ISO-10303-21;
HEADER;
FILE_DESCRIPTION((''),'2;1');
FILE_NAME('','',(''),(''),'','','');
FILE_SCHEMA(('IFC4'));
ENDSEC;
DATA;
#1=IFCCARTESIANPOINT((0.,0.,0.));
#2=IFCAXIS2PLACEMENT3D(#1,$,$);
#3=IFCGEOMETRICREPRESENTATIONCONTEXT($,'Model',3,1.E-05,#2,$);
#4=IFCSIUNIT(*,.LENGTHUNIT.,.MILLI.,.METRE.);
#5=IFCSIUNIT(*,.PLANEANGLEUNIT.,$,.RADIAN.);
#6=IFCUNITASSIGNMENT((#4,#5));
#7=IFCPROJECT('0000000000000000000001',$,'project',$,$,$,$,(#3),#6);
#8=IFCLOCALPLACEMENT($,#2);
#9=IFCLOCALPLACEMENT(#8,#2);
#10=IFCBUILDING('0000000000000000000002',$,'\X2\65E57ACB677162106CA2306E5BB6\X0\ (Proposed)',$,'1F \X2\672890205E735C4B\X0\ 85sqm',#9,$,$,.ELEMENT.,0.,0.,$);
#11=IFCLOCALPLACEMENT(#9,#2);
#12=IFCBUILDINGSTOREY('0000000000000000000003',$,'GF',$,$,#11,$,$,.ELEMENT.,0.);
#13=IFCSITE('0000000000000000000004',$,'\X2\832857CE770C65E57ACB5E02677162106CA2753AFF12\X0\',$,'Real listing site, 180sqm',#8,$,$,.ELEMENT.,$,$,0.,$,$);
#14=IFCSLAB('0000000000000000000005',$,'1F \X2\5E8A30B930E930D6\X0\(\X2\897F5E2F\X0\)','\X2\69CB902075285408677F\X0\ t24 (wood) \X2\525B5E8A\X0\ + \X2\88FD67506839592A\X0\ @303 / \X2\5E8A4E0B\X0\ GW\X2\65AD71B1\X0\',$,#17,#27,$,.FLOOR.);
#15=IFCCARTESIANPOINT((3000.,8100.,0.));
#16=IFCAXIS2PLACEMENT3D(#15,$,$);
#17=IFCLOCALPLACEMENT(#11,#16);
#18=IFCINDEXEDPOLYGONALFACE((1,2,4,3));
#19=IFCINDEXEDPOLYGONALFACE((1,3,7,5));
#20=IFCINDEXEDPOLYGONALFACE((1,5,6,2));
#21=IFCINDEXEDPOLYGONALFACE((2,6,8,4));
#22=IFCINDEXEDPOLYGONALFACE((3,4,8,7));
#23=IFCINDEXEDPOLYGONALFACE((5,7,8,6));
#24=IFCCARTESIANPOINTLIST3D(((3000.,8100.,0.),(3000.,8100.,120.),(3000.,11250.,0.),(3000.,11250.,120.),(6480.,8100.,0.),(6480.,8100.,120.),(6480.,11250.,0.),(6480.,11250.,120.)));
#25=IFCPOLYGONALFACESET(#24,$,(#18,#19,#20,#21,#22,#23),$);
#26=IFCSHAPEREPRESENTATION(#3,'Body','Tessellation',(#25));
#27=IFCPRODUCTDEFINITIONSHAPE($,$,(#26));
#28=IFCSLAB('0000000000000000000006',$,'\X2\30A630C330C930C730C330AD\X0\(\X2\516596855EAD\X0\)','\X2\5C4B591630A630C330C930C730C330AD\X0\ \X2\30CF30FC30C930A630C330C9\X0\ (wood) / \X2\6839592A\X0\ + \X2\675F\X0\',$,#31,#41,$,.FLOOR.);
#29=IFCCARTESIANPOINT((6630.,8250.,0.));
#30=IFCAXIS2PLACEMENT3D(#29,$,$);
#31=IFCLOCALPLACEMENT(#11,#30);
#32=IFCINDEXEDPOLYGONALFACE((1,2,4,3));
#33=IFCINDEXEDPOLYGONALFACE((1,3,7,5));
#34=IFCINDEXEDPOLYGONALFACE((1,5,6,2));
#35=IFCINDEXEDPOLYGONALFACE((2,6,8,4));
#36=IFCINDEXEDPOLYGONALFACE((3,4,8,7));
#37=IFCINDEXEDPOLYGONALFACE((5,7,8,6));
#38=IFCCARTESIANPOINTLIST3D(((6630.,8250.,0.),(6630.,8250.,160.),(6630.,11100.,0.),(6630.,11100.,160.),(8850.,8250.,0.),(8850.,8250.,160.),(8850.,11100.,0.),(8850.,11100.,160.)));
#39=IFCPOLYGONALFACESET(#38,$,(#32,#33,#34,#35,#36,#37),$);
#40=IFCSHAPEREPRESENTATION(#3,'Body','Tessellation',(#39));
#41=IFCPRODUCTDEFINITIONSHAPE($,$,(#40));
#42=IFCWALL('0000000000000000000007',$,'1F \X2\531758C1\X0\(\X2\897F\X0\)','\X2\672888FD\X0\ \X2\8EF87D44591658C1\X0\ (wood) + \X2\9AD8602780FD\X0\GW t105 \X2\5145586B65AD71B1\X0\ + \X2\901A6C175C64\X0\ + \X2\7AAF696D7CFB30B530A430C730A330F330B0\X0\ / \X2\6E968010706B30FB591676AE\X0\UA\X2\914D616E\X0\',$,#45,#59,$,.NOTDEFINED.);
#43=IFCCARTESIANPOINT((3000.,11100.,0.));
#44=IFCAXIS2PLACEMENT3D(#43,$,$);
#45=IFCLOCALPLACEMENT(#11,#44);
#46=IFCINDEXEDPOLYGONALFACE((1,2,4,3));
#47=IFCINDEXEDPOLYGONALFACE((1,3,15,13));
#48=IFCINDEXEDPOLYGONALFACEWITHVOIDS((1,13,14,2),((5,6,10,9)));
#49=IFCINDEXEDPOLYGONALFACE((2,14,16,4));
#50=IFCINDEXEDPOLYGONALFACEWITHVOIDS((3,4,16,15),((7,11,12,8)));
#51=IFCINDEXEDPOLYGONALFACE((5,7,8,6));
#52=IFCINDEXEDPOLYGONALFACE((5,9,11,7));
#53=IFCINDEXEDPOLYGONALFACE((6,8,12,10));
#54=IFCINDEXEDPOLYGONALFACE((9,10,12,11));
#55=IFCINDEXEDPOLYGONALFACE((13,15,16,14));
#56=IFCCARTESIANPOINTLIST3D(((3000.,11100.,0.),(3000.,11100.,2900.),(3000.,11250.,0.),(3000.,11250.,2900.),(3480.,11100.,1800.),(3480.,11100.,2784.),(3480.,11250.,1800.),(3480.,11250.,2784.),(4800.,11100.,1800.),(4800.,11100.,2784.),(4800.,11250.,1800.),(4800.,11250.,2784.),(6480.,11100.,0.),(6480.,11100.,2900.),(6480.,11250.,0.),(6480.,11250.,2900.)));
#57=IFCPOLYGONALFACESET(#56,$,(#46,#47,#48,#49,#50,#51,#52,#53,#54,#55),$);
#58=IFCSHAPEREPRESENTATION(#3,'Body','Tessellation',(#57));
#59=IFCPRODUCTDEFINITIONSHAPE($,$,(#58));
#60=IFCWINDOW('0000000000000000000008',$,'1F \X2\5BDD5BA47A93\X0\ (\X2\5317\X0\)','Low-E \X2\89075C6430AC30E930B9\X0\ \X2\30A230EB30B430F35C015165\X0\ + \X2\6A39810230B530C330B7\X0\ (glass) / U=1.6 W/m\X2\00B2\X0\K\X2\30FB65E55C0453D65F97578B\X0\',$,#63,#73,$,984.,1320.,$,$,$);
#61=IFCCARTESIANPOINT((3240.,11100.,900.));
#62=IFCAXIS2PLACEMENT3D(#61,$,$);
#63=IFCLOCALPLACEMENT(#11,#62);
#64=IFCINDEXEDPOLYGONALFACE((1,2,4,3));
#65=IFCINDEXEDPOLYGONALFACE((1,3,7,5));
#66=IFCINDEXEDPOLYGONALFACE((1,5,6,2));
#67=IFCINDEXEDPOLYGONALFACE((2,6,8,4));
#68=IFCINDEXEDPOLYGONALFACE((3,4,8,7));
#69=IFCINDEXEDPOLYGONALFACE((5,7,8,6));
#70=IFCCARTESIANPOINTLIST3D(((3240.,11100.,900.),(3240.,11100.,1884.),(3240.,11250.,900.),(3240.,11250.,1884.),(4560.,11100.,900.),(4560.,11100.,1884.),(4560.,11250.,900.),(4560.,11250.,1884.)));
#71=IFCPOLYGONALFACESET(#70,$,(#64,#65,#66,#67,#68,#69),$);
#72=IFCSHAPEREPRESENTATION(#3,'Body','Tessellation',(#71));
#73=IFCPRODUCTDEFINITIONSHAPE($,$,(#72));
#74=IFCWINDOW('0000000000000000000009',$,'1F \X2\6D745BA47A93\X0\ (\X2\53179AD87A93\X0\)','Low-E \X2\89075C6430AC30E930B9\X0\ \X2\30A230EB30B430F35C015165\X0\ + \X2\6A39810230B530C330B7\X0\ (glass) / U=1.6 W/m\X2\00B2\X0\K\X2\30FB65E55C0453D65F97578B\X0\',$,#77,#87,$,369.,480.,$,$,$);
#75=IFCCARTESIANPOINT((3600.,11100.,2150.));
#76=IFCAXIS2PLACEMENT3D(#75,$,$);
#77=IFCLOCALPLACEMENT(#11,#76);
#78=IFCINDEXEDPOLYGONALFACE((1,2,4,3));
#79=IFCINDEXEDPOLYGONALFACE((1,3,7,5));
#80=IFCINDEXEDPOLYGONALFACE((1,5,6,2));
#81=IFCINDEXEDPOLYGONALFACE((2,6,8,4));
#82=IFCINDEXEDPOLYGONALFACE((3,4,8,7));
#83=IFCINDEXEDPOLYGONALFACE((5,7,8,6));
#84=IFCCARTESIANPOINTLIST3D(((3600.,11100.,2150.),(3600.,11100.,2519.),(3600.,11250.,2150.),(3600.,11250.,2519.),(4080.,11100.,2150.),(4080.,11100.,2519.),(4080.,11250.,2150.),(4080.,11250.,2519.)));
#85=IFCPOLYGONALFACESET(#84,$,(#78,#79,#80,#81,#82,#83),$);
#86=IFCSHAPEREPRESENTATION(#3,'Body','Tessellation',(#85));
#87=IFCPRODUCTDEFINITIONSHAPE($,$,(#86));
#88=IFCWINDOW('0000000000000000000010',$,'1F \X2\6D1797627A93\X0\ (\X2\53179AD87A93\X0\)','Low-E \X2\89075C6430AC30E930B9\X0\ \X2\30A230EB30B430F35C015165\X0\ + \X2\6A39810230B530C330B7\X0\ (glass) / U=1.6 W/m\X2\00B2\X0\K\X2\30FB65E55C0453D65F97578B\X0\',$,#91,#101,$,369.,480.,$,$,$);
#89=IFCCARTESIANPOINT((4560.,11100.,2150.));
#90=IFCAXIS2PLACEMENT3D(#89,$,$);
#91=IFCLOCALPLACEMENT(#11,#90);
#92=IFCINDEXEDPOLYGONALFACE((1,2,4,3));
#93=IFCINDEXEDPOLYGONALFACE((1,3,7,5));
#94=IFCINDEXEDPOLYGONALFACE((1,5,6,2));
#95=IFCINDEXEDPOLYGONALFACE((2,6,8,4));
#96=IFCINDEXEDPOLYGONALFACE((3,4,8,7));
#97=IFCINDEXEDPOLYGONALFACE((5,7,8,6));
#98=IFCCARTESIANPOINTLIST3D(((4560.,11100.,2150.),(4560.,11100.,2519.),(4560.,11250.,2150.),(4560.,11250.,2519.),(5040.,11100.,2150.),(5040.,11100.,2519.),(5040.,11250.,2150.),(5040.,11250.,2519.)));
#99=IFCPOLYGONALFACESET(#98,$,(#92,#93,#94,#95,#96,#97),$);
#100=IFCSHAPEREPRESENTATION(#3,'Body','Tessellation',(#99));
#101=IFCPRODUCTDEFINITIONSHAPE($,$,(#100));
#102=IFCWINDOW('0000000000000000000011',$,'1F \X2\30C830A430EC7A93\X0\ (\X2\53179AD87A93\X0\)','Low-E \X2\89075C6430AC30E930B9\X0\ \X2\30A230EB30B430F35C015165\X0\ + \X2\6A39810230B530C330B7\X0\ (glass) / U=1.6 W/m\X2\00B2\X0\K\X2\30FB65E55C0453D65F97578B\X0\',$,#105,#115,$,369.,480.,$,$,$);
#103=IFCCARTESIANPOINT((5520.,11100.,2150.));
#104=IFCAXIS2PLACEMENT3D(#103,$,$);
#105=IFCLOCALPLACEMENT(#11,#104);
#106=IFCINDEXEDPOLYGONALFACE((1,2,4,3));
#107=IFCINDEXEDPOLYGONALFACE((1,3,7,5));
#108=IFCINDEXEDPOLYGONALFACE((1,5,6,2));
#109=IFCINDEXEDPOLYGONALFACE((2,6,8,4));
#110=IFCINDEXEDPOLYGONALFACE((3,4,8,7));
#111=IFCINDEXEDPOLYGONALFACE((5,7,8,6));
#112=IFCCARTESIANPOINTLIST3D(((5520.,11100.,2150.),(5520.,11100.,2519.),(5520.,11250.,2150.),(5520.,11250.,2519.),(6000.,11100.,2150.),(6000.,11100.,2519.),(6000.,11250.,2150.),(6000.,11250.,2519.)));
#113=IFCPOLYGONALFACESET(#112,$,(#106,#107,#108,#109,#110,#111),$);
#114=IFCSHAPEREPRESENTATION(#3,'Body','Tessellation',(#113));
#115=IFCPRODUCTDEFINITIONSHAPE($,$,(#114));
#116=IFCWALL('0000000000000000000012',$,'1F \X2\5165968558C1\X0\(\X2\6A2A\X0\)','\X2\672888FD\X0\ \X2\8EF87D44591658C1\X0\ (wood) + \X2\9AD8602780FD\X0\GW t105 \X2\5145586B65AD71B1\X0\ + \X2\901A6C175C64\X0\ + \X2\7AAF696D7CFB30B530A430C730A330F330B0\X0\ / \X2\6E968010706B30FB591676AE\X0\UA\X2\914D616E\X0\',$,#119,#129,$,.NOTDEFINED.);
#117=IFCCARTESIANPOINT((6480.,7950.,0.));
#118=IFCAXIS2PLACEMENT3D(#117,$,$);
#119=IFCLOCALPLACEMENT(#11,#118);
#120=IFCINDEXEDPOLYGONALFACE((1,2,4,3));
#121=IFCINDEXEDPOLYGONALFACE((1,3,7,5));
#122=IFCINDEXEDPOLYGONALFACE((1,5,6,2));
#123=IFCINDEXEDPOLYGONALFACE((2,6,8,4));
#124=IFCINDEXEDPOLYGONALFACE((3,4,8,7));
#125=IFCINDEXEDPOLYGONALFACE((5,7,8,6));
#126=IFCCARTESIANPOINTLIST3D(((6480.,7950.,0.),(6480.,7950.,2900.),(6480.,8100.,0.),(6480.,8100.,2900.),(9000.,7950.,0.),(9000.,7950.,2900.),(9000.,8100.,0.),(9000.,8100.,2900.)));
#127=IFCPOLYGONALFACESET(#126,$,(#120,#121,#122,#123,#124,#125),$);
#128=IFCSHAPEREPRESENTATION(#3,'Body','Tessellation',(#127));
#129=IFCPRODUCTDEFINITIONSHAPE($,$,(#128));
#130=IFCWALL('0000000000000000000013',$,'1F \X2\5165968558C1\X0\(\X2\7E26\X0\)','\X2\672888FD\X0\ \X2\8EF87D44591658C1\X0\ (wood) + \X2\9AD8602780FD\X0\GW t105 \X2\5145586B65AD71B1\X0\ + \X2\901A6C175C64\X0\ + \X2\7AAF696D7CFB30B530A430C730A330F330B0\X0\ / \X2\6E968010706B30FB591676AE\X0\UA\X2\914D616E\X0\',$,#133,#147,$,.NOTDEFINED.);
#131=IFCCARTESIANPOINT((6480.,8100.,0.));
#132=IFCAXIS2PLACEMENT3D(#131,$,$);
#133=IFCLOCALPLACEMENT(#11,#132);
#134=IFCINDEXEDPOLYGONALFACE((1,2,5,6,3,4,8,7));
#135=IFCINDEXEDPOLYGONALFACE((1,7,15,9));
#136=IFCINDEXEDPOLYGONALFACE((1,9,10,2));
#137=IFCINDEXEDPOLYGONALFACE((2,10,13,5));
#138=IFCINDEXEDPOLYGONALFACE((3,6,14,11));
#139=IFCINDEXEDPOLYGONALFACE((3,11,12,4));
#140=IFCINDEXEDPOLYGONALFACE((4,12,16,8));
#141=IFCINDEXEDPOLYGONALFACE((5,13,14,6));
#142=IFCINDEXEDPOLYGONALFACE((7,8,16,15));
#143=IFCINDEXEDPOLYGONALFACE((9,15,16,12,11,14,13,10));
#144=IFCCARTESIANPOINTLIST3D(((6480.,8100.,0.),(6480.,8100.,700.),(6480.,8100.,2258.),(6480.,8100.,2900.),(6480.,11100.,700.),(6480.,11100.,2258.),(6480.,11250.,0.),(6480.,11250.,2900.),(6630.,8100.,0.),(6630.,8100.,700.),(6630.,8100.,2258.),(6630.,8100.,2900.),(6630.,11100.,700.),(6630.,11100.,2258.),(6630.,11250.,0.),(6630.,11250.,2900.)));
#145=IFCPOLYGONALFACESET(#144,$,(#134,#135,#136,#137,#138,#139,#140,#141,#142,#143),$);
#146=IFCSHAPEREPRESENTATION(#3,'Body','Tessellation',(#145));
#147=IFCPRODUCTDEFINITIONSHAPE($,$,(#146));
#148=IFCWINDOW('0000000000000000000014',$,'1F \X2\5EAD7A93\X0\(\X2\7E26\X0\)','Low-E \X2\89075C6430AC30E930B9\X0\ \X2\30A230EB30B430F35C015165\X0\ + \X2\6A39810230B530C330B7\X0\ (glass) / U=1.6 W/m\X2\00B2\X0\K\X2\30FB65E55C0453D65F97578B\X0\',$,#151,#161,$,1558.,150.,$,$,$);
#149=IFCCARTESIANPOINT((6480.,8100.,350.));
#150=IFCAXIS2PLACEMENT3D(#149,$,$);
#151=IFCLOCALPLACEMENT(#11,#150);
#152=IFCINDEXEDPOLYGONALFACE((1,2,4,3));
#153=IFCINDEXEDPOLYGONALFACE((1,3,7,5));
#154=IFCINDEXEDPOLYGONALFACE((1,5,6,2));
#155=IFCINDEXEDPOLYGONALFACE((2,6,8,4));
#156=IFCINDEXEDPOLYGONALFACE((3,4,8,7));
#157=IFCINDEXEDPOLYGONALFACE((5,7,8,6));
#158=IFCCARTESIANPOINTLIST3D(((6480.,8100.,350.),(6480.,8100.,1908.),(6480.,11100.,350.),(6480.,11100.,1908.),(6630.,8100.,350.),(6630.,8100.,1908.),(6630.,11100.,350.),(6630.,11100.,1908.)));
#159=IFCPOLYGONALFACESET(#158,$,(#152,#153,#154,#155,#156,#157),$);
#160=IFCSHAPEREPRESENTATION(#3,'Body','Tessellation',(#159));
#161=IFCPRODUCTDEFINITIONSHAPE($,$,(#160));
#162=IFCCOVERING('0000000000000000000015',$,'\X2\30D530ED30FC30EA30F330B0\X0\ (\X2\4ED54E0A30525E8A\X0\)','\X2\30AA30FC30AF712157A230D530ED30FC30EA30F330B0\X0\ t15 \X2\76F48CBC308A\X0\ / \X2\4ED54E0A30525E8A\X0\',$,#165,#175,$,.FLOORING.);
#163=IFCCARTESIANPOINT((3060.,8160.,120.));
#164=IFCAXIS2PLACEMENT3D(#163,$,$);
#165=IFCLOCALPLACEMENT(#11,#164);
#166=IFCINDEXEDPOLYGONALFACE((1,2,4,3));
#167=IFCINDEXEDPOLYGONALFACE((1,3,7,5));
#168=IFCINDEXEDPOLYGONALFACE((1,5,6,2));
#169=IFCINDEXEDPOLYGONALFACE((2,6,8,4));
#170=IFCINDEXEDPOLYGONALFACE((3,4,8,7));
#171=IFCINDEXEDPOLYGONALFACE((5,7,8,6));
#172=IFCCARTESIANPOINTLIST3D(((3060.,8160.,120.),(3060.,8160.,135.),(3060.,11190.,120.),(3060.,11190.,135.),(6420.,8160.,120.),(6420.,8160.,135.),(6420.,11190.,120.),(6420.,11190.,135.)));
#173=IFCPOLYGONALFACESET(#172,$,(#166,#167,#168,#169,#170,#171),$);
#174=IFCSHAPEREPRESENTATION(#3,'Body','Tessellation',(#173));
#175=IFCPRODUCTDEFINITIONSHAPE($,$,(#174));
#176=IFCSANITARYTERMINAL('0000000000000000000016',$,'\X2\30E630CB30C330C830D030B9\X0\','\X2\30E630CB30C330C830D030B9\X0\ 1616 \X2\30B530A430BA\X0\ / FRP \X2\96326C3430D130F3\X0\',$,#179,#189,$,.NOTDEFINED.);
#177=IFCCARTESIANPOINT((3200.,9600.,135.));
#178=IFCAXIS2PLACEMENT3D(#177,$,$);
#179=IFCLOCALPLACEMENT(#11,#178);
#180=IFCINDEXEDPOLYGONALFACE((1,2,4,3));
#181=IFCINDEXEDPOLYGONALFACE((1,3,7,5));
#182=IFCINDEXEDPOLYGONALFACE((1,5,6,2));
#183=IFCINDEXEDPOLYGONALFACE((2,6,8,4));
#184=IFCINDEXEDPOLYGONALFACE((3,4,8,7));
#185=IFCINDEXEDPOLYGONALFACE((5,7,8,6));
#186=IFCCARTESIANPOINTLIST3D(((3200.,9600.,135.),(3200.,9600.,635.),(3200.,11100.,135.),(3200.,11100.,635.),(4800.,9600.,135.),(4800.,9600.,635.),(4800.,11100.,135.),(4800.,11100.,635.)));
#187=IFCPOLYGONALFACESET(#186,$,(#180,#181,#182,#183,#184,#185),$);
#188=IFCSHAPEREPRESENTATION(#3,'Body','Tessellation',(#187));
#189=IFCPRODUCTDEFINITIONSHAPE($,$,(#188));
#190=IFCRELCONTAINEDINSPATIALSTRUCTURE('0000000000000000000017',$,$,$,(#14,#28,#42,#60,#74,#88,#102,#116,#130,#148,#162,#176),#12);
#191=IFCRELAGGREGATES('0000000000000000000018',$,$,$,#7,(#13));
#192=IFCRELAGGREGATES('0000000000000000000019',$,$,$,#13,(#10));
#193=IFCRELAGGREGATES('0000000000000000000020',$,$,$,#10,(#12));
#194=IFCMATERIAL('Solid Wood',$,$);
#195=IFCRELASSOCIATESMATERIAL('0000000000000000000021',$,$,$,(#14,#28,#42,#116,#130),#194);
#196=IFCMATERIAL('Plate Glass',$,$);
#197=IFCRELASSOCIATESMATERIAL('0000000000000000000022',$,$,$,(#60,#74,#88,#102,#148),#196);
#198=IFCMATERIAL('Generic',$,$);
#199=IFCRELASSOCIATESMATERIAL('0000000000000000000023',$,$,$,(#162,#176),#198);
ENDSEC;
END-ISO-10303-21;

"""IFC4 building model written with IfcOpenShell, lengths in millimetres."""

from ifc_helpers import new_model, si_unit, frame, frame_2d, origin, place, context, project, spatial, rectangle, extrude, material, element, fill, save


model = new_model("IFC4")

# Units and contexts
model_context = context("Model", 3, precision=1e-05, world=origin())
ifc_project = project(units=[si_unit("LENGTHUNIT", "METRE", prefix="MILLI"), si_unit("PLANEANGLEUNIT", "RADIAN")], contexts=[model_context])

# Site, building, storey
site_placement = place(None, origin())
site = spatial("IfcSite", under=ifc_project, at=site_placement, Name="茨城県日立市東成沢町２", ObjectType="Real listing site, 180sqm", CompositionType="ELEMENT", RefElevation=0.0)
building_placement = place(site_placement, origin())
building = spatial("IfcBuilding", under=site, at=building_placement, Name="日立東成沢の家 (Proposed)", ObjectType="1F 木造平屋 85sqm", CompositionType="ELEMENT", ElevationOfRefHeight=0.0, ElevationOfTerrain=0.0)
storey_placement = place(building_placement, origin())
storey = spatial("IfcBuildingStorey", under=building, at=storey_placement, Name="GF", CompositionType="ELEMENT", Elevation=0.0)

# Slabs
ifc_material_1 = material(Name="Solid Wood")
slab_1_placement = place(storey_placement, frame((3000.0, 8100.0, 0.0)))
element("IfcSlab", 1, at=slab_1_placement, inside=storey, material=ifc_material_1, Name="1F 床スラブ(西帯)", Description="構造用合板 t24 (wood) 剛床 + 製材根太 @303 / 床下 GW断熱", PredefinedType="FLOOR", context=model_context, shape_type="SweptSolid", body=[
    extrude(rectangle(XDim=3480.0, YDim=3150.0, at=frame_2d((1740.0, 1575.0))), frame((3000.0, 8100.0, 0.0)), (0.0, 0.0, 1.0), 120.0),
])
slab_2_placement = place(storey_placement, frame((6630.0, 8250.0, 0.0)))
element("IfcSlab", 2, at=slab_2_placement, inside=storey, material=ifc_material_1, Name="ウッドデッキ(入隅庭)", Description="屋外ウッドデッキ ハードウッド (wood) / 根太 + 束", PredefinedType="FLOOR", context=model_context, shape_type="SweptSolid", body=[
    extrude(rectangle(XDim=2220.0, YDim=2850.0, at=frame_2d((1110.0, 1425.0))), frame((6630.0, 8250.0, 0.0)), (0.0, 0.0, 1.0), 160.0),
])

# Wall, openings, windows
wall_1_placement = place(storey_placement, frame((3000.0, 11100.0, 0.0)))
wall_1 = element("IfcWall", 3, at=wall_1_placement, inside=storey, material=ifc_material_1, Name="1F 北壁(西)", Description="木製 軸組外壁 (wood) + 高性能GW t105 充填断熱 + 通気層 + 窯業系サイディング / 準耐火・外皮UA配慮", PredefinedType="NOTDEFINED", context=model_context, shape_type="SweptSolid", body=[
    extrude(rectangle(XDim=3480.0, YDim=150.0, at=frame_2d((1740.0, 75.0))), frame((3000.0, 11100.0, 0.0)), (0.0, 0.0, 1.0), 2900.0),
])
opening_1_placement = place(storey_placement, frame((3240.0, 11100.0, 900.0)))
opening_1 = element("IfcOpeningElement", 4, at=opening_1_placement, cuts=wall_1, PredefinedType="NOTDEFINED", context=model_context, shape_type="SweptSolid", body=[
    extrude(rectangle(XDim=1320.0, YDim=150.0, at=frame_2d((660.0, 75.0))), frame((3240.0, 11100.0, 900.0)), (0.0, 0.0, 1.0), 984.0),
])
opening_2_placement = place(storey_placement, frame((3600.0, 11100.0, 2150.0)))
opening_2 = element("IfcOpeningElement", 5, at=opening_2_placement, cuts=wall_1, PredefinedType="NOTDEFINED", context=model_context, shape_type="SweptSolid", body=[
    extrude(rectangle(XDim=480.0, YDim=150.0, at=frame_2d((240.0, 75.0))), frame((3600.0, 11100.0, 2150.0)), (0.0, 0.0, 1.0), 369.0),
])
opening_3_placement = place(storey_placement, frame((4560.0, 11100.0, 2150.0)))
opening_3 = element("IfcOpeningElement", 6, at=opening_3_placement, cuts=wall_1, PredefinedType="NOTDEFINED", context=model_context, shape_type="SweptSolid", body=[
    extrude(rectangle(XDim=480.0, YDim=150.0, at=frame_2d((240.0, 75.0))), frame((4560.0, 11100.0, 2150.0)), (0.0, 0.0, 1.0), 369.0),
])
opening_4_placement = place(storey_placement, frame((5520.0, 11100.0, 2150.0)))
opening_4 = element("IfcOpeningElement", 7, at=opening_4_placement, cuts=wall_1, PredefinedType="NOTDEFINED", context=model_context, shape_type="SweptSolid", body=[
    extrude(rectangle(XDim=480.0, YDim=150.0, at=frame_2d((240.0, 75.0))), frame((5520.0, 11100.0, 2150.0)), (0.0, 0.0, 1.0), 369.0),
])
ifc_material_2 = material(Name="Plate Glass")
window_1_placement = place(storey_placement, frame((3240.0, 11100.0, 900.0)))
window_1 = element("IfcWindow", 8, at=window_1_placement, inside=storey, material=ifc_material_2, Name="1F 寝室窓 (北)", Description="Low-E 複層ガラス アルゴン封入 + 樹脂サッシ (glass) / U=1.6 W/m²K・日射取得型", OverallHeight=984.0, OverallWidth=1320.0, context=model_context, shape_type="SweptSolid", body=[
    extrude(rectangle(XDim=1320.0, YDim=150.0, at=frame_2d((660.0, 75.0))), frame((3240.0, 11100.0, 900.0)), (0.0, 0.0, 1.0), 984.0),
])
fill(opening_1, window_1)
window_2_placement = place(storey_placement, frame((3600.0, 11100.0, 2150.0)))
window_2 = element("IfcWindow", 9, at=window_2_placement, inside=storey, material=ifc_material_2, Name="1F 浴室窓 (北高窓)", Description="Low-E 複層ガラス アルゴン封入 + 樹脂サッシ (glass) / U=1.6 W/m²K・日射取得型", OverallHeight=369.0, OverallWidth=480.0, context=model_context, shape_type="SweptSolid", body=[
    extrude(rectangle(XDim=480.0, YDim=150.0, at=frame_2d((240.0, 75.0))), frame((3600.0, 11100.0, 2150.0)), (0.0, 0.0, 1.0), 369.0),
])
fill(opening_2, window_2)
window_3_placement = place(storey_placement, frame((4560.0, 11100.0, 2150.0)))
window_3 = element("IfcWindow", 10, at=window_3_placement, inside=storey, material=ifc_material_2, Name="1F 洗面窓 (北高窓)", Description="Low-E 複層ガラス アルゴン封入 + 樹脂サッシ (glass) / U=1.6 W/m²K・日射取得型", OverallHeight=369.0, OverallWidth=480.0, context=model_context, shape_type="SweptSolid", body=[
    extrude(rectangle(XDim=480.0, YDim=150.0, at=frame_2d((240.0, 75.0))), frame((4560.0, 11100.0, 2150.0)), (0.0, 0.0, 1.0), 369.0),
])
fill(opening_3, window_3)
window_4_placement = place(storey_placement, frame((5520.0, 11100.0, 2150.0)))
window_4 = element("IfcWindow", 11, at=window_4_placement, inside=storey, material=ifc_material_2, Name="1F トイレ窓 (北高窓)", Description="Low-E 複層ガラス アルゴン封入 + 樹脂サッシ (glass) / U=1.6 W/m²K・日射取得型", OverallHeight=369.0, OverallWidth=480.0, context=model_context, shape_type="SweptSolid", body=[
    extrude(rectangle(XDim=480.0, YDim=150.0, at=frame_2d((240.0, 75.0))), frame((5520.0, 11100.0, 2150.0)), (0.0, 0.0, 1.0), 369.0),
])
fill(opening_4, window_4)

# Wall
wall_2_placement = place(storey_placement, frame((6480.0, 7950.0, 0.0)))
element("IfcWall", 12, at=wall_2_placement, inside=storey, material=ifc_material_1, Name="1F 入隅壁(横)", Description="木製 軸組外壁 (wood) + 高性能GW t105 充填断熱 + 通気層 + 窯業系サイディング / 準耐火・外皮UA配慮", PredefinedType="NOTDEFINED", context=model_context, shape_type="SweptSolid", body=[
    extrude(rectangle(XDim=2520.0, YDim=150.0, at=frame_2d((1260.0, 75.0))), frame((6480.0, 7950.0, 0.0)), (0.0, 0.0, 1.0), 2900.0),
])

# Wall, opening, window
wall_3_placement = place(storey_placement, frame((6480.0, 8100.0, 0.0)))
wall_3 = element("IfcWall", 13, at=wall_3_placement, inside=storey, material=ifc_material_1, Name="1F 入隅壁(縦)", Description="木製 軸組外壁 (wood) + 高性能GW t105 充填断熱 + 通気層 + 窯業系サイディング / 準耐火・外皮UA配慮", PredefinedType="NOTDEFINED", context=model_context, shape_type="SweptSolid", body=[
    extrude(rectangle(XDim=150.0, YDim=3150.0, at=frame_2d((75.0, 1575.0))), frame((6480.0, 8100.0, 0.0)), (0.0, 0.0, 1.0), 2900.0),
])
opening_5_placement = place(storey_placement, frame((6480.0, 8100.0, 350.0)))
opening_5 = element("IfcOpeningElement", 14, at=opening_5_placement, cuts=wall_3, PredefinedType="NOTDEFINED", context=model_context, shape_type="SweptSolid", body=[
    extrude(rectangle(XDim=150.0, YDim=3000.0, at=frame_2d((75.0, 1500.0))), frame((6480.0, 8100.0, 350.0)), (0.0, 0.0, 1.0), 1558.0),
])
window_5_placement = place(storey_placement, frame((6480.0, 8100.0, 350.0)))
window_5 = element("IfcWindow", 15, at=window_5_placement, inside=storey, material=ifc_material_2, Name="1F 庭窓(縦)", Description="Low-E 複層ガラス アルゴン封入 + 樹脂サッシ (glass) / U=1.6 W/m²K・日射取得型", OverallHeight=1558.0, OverallWidth=150.0, context=model_context, shape_type="SweptSolid", body=[
    extrude(rectangle(XDim=150.0, YDim=3000.0, at=frame_2d((75.0, 1500.0))), frame((6480.0, 8100.0, 350.0)), (0.0, 0.0, 1.0), 1558.0),
])
fill(opening_5, window_5)

# Covering
ifc_material_3 = material(Name="Generic")
covering_placement = place(storey_placement, frame((3060.0, 8160.0, 120.0)))
element("IfcCovering", 16, at=covering_placement, inside=storey, material=ifc_material_3, Name="フローリング (仕上げ床)", Description="オーク無垢フローリング t15 直貼り / 仕上げ床", PredefinedType="FLOORING", context=model_context, shape_type="SweptSolid", body=[
    extrude(rectangle(XDim=3360.0, YDim=3030.0, at=frame_2d((1680.0, 1515.0))), frame((3060.0, 8160.0, 120.0)), (0.0, 0.0, 1.0), 15.0),
])

# Sanitary terminal
sanitary_terminal_1_placement = place(storey_placement, frame((3200.0, 9600.0, 135.0)))
element("IfcSanitaryTerminal", 17, at=sanitary_terminal_1_placement, inside=storey, material=ifc_material_3, Name="ユニットバス", Description="ユニットバス 1616 サイズ / FRP 防水パン", PredefinedType="NOTDEFINED", context=model_context, shape_type="SweptSolid", body=[
    extrude(rectangle(XDim=1600.0, YDim=1500.0, at=frame_2d((800.0, 750.0))), frame((3200.0, 9600.0, 135.0)), (0.0, 0.0, 1.0), 500.0),
])

save(model, "model.ifc")
